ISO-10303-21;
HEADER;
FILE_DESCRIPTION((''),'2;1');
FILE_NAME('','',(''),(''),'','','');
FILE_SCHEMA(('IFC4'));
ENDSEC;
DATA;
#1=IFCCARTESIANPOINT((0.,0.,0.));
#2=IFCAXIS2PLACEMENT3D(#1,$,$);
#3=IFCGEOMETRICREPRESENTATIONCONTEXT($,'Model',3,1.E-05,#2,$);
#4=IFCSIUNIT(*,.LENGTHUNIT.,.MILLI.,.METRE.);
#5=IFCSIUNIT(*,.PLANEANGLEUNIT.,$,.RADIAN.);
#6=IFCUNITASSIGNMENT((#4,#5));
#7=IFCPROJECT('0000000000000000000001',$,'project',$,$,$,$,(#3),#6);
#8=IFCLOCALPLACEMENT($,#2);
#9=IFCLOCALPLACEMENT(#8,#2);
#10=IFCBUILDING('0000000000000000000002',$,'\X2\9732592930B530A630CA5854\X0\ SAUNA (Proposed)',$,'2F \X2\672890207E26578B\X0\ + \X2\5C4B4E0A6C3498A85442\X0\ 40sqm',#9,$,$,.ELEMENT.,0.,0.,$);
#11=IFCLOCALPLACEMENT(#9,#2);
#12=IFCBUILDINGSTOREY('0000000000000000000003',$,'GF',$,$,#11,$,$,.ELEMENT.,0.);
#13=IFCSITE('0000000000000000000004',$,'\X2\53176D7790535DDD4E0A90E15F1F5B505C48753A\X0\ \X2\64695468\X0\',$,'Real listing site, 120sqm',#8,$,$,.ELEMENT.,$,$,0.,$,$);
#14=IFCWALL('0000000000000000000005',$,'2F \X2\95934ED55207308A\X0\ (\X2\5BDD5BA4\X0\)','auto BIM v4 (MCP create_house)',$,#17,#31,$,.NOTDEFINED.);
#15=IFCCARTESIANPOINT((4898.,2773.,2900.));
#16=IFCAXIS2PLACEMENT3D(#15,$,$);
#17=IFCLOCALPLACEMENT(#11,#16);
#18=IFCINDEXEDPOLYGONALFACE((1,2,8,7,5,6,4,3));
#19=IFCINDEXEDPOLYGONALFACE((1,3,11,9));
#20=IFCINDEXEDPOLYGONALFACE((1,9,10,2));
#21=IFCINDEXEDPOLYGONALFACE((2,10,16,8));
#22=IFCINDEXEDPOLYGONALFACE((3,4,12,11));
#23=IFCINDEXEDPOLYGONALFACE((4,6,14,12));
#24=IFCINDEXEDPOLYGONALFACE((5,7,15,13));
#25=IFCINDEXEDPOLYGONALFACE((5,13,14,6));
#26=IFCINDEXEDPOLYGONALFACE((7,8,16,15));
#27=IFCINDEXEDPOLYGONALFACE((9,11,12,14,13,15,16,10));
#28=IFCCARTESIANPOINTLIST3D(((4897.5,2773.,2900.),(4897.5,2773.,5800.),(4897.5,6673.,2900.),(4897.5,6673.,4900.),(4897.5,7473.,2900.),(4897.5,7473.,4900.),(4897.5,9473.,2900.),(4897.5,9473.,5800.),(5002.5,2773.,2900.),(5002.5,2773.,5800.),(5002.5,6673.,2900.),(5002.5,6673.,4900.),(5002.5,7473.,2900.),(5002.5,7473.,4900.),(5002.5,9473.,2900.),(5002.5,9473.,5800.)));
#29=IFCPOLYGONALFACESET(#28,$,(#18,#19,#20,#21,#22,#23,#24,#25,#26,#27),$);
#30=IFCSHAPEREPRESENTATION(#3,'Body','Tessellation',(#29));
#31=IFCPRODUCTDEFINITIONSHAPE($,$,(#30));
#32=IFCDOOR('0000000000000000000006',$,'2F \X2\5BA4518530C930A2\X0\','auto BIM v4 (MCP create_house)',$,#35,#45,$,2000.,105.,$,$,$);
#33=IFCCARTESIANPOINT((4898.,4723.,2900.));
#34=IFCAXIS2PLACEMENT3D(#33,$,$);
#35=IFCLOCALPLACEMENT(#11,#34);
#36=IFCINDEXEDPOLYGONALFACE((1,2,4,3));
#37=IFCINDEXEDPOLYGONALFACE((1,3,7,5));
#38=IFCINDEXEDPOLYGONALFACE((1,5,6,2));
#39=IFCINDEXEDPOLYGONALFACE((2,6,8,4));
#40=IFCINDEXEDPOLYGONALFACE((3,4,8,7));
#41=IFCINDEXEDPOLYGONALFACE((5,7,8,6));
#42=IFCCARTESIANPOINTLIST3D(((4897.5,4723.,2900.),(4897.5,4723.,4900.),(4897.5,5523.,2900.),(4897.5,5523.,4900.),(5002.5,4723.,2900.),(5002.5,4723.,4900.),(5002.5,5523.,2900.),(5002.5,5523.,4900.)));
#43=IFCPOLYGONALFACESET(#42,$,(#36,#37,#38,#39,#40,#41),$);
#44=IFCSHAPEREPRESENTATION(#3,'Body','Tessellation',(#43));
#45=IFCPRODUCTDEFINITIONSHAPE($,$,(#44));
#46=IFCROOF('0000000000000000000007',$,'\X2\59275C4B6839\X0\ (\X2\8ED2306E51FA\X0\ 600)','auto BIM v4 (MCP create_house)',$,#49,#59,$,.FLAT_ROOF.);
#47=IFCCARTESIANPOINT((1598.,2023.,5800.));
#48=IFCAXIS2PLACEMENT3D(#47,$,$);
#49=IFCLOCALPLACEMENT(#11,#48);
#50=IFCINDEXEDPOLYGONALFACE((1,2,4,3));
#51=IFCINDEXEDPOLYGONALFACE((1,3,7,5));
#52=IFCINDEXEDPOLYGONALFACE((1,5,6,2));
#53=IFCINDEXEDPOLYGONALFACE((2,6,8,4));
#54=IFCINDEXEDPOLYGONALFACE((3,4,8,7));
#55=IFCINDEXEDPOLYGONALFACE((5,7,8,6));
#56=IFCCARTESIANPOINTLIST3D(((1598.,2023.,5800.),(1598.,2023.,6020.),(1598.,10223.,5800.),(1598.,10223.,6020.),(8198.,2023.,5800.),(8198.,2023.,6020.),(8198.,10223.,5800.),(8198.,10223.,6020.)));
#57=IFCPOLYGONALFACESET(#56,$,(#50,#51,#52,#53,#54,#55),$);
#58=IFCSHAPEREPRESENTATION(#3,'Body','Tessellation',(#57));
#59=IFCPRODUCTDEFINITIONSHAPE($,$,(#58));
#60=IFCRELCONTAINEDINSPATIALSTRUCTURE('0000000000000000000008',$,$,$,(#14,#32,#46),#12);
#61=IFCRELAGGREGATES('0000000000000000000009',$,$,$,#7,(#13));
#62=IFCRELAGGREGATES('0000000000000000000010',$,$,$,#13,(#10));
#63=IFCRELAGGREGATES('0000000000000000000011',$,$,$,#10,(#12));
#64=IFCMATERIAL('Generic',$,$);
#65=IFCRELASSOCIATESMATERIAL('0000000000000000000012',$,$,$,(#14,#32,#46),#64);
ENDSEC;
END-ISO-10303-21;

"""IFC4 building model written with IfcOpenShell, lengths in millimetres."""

from ifc_helpers import new_model, si_unit, frame, frame_2d, origin, place, context, project, spatial, rectangle, extrude, material, element, fill, save


model = new_model("IFC4")

# Units and contexts
model_context = context("Model", 3, precision=1e-05, world=origin())
ifc_project = project(units=[si_unit("LENGTHUNIT", "METRE", prefix="MILLI"), si_unit("PLANEANGLEUNIT", "RADIAN")], contexts=[model_context])

# Site, building, storey
site_placement = place(None, origin())
site = spatial("IfcSite", under=ifc_project, at=site_placement, Name="北海道川上郡弟子屈町 摩周", ObjectType="Real listing site, 120sqm", CompositionType="ELEMENT", RefElevation=0.0)
building_placement = place(site_placement, origin())
building = spatial("IfcBuilding", under=site, at=building_placement, Name="露天サウナ塔 SAUNA (Proposed)", ObjectType="2F 木造縦型 + 屋上水風呂 40sqm", CompositionType="ELEMENT", ElevationOfRefHeight=0.0, ElevationOfTerrain=0.0)
storey_placement = place(building_placement, origin())
storey = spatial("IfcBuildingStorey", under=building, at=storey_placement, Name="GF", CompositionType="ELEMENT", Elevation=0.0)

# Shared definitions
ifc_material = material(Name="Generic")

# Wall, opening, door
wall_1_placement = place(storey_placement, frame((4898.0, 2773.0, 2900.0)))
wall_1 = element("IfcWall", 1, at=wall_1_placement, inside=storey, material=ifc_material, Name="2F 間仕切り (寝室)", Description="auto BIM v4 (MCP create_house)", PredefinedType="NOTDEFINED", context=model_context, shape_type="SweptSolid", body=[
    extrude(rectangle(XDim=105.0, YDim=6700.0, at=frame_2d((52.0, 3350.0))), frame((4898.0, 2773.0, 2900.0)), (0.0, 0.0, 1.0), 2900.0),
])
opening_1_placement = place(storey_placement, frame((4898.0, 4723.0, 2900.0)))
opening_1 = element("IfcOpeningElement", 2, at=opening_1_placement, cuts=wall_1, PredefinedType="NOTDEFINED", context=model_context, shape_type="SweptSolid", body=[
    extrude(rectangle(XDim=105.0, YDim=800.0, at=frame_2d((52.0, 400.0))), frame((4898.0, 4723.0, 2900.0)), (0.0, 0.0, 1.0), 2000.0),
])
door_1_placement = place(storey_placement, frame((4898.0, 4723.0, 2900.0)))
door_1 = element("IfcDoor", 3, at=door_1_placement, inside=storey, material=ifc_material, Name="2F 室内ドア", Description="auto BIM v4 (MCP create_house)", OverallHeight=2000.0, OverallWidth=105.0, context=model_context, shape_type="SweptSolid", body=[
    extrude(rectangle(XDim=105.0, YDim=800.0, at=frame_2d((52.0, 400.0))), frame((4898.0, 4723.0, 2900.0)), (0.0, 0.0, 1.0), 2000.0),
])
fill(opening_1, door_1)

# Roof
roof_placement = place(storey_placement, frame((1598.0, 2023.0, 5800.0)))
element("IfcRoof", 4, at=roof_placement, inside=storey, material=ifc_material, Name="大屋根 (軒の出 600)", Description="auto BIM v4 (MCP create_house)", PredefinedType="FLAT_ROOF", context=model_context, shape_type="SweptSolid", body=[
    extrude(rectangle(XDim=6600.0, YDim=8200.0, at=frame_2d((3300.0, 4100.0))), frame((1598.0, 2023.0, 5800.0)), (0.0, 0.0, 1.0), 220.0),
])

save(model, "model.ifc")
